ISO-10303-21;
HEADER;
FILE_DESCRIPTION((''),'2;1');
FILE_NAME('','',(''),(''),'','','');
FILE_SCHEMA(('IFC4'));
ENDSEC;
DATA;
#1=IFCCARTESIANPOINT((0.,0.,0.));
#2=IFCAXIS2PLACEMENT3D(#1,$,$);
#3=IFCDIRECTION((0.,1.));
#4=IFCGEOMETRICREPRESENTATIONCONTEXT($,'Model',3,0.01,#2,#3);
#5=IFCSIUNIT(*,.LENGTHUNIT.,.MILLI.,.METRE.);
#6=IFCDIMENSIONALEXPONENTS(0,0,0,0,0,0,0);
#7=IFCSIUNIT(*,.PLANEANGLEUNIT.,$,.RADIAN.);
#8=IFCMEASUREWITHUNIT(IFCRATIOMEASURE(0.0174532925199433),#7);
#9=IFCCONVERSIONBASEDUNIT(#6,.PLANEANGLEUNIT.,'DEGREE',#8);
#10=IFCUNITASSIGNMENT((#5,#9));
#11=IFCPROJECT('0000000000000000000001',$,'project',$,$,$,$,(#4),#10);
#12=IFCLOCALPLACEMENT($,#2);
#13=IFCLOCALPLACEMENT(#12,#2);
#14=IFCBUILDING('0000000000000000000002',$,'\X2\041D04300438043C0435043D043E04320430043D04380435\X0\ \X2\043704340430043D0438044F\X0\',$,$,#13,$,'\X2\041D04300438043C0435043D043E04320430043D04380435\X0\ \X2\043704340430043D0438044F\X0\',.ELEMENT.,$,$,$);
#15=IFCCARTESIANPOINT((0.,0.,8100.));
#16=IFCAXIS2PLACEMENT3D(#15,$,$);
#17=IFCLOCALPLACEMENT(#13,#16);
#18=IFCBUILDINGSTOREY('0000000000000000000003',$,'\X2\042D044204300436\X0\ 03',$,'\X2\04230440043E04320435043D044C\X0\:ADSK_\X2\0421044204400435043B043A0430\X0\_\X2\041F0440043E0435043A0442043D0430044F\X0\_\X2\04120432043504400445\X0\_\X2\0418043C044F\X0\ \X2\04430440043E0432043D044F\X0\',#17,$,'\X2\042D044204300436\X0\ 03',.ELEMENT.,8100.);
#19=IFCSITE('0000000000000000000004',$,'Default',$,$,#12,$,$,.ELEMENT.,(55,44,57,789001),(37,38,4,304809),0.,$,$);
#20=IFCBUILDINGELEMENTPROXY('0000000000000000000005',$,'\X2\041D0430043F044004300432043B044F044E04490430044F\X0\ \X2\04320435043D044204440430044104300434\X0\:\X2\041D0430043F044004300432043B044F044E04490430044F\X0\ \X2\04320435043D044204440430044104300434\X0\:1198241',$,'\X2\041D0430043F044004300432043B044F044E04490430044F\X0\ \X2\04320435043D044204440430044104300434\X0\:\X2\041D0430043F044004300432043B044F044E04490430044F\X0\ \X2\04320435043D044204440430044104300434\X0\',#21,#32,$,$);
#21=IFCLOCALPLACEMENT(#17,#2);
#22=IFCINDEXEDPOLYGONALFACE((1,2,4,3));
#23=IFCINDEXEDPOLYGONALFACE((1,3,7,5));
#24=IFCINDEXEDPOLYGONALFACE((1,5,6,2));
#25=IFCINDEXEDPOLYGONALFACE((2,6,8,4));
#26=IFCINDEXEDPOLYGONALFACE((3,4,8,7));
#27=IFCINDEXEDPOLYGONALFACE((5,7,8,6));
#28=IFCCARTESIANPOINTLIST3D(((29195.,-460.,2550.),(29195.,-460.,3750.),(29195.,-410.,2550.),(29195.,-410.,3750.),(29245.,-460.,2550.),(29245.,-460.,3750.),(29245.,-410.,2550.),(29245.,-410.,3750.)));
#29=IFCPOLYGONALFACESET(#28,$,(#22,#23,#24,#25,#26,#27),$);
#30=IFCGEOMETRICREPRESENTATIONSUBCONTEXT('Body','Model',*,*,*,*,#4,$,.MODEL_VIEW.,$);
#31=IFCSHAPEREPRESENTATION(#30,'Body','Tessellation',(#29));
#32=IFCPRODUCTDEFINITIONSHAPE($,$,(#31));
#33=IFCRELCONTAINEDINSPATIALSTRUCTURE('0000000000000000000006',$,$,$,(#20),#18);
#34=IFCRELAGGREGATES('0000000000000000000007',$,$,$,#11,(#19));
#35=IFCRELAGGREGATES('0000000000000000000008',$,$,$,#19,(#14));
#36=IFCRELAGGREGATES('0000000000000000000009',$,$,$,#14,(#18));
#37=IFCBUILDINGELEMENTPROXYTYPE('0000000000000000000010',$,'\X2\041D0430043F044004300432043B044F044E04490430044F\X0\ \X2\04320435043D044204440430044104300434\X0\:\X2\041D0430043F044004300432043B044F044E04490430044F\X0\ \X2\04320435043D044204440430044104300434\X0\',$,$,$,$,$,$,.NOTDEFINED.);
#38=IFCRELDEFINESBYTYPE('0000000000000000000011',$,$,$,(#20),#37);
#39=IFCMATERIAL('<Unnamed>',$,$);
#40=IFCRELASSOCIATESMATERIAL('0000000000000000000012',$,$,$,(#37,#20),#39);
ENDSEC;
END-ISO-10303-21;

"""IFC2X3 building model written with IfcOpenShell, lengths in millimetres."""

from ifc_helpers import new_model, entity, si_unit, converted_unit, direction, frame, origin, origin_2d_with_axis, place, context, subcontext, project, spatial, rectangle, extrude, source, transform, mapped, material, type_object, type_shapes, element, save


model = new_model("IFC2X3")

# Units and contexts
model_context = context("Model", 3, precision=0.01, world=origin(), true_north=direction((0.0, 1.0)))
body_context = subcontext(model_context, "Body", "Model", "MODEL_VIEW")
ifc_project = project(units=[si_unit("LENGTHUNIT", "METRE", prefix="MILLI"), converted_unit("PLANEANGLEUNIT", "DEGREE", entity("IfcRatioMeasure", 0.0174532925199433), si_unit("PLANEANGLEUNIT", "RADIAN"), dimensions=[0, 0, 0, 0, 0, 0, 0])], contexts=[model_context])

# Site, building, storey
site_placement = place(None, origin())
site = spatial("IfcSite", under=ifc_project, at=site_placement, Name="Default", CompositionType="ELEMENT", RefLatitude=(55, 44, 57, 789001), RefLongitude=(37, 38, 4, 304809), RefElevation=0.0)
building_placement = place(site_placement, origin())
building = spatial("IfcBuilding", under=site, at=building_placement, Name="Наименование здания", LongName="Наименование здания", CompositionType="ELEMENT")
storey_placement = place(building_placement, frame((0.0, 0.0, 8100.0)))
storey = spatial("IfcBuildingStorey", under=building, at=storey_placement, Name="Этаж 03", ObjectType="Уровень:ADSK_Стрелка_Проектная_Вверх_Имя уровня", LongName="Этаж 03", CompositionType="ELEMENT", Elevation=8100.0)

# Building element proxy
ifc_material_1 = material(Name="<Unnamed>")
building_element_proxy_type_1 = type_object("IfcBuildingElementProxyType", Name="Направляющая вентфасад:Направляющая вентфасад", PredefinedType="NOTDEFINED", material=ifc_material_1)
shared_shape_1 = source(origin(), body_context, "Body", "SweptSolid", [
    extrude(rectangle(XDim=50.0, YDim=50.0, at=origin_2d_with_axis()), frame((25.0, -25.0, 0.0), z_axis=(0.0, 0.0, 1.0), x_axis=(-1.0, 0.0, 0.0)), (0.0, 0.0, 1.0), 1200.0),
])
type_shapes(building_element_proxy_type_1, [shared_shape_1])
proxy_1_placement = place(storey_placement, frame((29195.0, -410.0, 2550.0)))
element("IfcBuildingElementProxy", 1, at=proxy_1_placement, inside=storey, type_object=building_element_proxy_type_1, material=ifc_material_1, Name="Направляющая вентфасад:Направляющая вентфасад:1198241", ObjectType="Направляющая вентфасад:Направляющая вентфасад", context=body_context, shape_type="MappedRepresentation", body=[
    mapped(shared_shape_1, transform((0.0, 0.0, 0.0), scale=1.0)),
])

save(model, "model.ifc")
